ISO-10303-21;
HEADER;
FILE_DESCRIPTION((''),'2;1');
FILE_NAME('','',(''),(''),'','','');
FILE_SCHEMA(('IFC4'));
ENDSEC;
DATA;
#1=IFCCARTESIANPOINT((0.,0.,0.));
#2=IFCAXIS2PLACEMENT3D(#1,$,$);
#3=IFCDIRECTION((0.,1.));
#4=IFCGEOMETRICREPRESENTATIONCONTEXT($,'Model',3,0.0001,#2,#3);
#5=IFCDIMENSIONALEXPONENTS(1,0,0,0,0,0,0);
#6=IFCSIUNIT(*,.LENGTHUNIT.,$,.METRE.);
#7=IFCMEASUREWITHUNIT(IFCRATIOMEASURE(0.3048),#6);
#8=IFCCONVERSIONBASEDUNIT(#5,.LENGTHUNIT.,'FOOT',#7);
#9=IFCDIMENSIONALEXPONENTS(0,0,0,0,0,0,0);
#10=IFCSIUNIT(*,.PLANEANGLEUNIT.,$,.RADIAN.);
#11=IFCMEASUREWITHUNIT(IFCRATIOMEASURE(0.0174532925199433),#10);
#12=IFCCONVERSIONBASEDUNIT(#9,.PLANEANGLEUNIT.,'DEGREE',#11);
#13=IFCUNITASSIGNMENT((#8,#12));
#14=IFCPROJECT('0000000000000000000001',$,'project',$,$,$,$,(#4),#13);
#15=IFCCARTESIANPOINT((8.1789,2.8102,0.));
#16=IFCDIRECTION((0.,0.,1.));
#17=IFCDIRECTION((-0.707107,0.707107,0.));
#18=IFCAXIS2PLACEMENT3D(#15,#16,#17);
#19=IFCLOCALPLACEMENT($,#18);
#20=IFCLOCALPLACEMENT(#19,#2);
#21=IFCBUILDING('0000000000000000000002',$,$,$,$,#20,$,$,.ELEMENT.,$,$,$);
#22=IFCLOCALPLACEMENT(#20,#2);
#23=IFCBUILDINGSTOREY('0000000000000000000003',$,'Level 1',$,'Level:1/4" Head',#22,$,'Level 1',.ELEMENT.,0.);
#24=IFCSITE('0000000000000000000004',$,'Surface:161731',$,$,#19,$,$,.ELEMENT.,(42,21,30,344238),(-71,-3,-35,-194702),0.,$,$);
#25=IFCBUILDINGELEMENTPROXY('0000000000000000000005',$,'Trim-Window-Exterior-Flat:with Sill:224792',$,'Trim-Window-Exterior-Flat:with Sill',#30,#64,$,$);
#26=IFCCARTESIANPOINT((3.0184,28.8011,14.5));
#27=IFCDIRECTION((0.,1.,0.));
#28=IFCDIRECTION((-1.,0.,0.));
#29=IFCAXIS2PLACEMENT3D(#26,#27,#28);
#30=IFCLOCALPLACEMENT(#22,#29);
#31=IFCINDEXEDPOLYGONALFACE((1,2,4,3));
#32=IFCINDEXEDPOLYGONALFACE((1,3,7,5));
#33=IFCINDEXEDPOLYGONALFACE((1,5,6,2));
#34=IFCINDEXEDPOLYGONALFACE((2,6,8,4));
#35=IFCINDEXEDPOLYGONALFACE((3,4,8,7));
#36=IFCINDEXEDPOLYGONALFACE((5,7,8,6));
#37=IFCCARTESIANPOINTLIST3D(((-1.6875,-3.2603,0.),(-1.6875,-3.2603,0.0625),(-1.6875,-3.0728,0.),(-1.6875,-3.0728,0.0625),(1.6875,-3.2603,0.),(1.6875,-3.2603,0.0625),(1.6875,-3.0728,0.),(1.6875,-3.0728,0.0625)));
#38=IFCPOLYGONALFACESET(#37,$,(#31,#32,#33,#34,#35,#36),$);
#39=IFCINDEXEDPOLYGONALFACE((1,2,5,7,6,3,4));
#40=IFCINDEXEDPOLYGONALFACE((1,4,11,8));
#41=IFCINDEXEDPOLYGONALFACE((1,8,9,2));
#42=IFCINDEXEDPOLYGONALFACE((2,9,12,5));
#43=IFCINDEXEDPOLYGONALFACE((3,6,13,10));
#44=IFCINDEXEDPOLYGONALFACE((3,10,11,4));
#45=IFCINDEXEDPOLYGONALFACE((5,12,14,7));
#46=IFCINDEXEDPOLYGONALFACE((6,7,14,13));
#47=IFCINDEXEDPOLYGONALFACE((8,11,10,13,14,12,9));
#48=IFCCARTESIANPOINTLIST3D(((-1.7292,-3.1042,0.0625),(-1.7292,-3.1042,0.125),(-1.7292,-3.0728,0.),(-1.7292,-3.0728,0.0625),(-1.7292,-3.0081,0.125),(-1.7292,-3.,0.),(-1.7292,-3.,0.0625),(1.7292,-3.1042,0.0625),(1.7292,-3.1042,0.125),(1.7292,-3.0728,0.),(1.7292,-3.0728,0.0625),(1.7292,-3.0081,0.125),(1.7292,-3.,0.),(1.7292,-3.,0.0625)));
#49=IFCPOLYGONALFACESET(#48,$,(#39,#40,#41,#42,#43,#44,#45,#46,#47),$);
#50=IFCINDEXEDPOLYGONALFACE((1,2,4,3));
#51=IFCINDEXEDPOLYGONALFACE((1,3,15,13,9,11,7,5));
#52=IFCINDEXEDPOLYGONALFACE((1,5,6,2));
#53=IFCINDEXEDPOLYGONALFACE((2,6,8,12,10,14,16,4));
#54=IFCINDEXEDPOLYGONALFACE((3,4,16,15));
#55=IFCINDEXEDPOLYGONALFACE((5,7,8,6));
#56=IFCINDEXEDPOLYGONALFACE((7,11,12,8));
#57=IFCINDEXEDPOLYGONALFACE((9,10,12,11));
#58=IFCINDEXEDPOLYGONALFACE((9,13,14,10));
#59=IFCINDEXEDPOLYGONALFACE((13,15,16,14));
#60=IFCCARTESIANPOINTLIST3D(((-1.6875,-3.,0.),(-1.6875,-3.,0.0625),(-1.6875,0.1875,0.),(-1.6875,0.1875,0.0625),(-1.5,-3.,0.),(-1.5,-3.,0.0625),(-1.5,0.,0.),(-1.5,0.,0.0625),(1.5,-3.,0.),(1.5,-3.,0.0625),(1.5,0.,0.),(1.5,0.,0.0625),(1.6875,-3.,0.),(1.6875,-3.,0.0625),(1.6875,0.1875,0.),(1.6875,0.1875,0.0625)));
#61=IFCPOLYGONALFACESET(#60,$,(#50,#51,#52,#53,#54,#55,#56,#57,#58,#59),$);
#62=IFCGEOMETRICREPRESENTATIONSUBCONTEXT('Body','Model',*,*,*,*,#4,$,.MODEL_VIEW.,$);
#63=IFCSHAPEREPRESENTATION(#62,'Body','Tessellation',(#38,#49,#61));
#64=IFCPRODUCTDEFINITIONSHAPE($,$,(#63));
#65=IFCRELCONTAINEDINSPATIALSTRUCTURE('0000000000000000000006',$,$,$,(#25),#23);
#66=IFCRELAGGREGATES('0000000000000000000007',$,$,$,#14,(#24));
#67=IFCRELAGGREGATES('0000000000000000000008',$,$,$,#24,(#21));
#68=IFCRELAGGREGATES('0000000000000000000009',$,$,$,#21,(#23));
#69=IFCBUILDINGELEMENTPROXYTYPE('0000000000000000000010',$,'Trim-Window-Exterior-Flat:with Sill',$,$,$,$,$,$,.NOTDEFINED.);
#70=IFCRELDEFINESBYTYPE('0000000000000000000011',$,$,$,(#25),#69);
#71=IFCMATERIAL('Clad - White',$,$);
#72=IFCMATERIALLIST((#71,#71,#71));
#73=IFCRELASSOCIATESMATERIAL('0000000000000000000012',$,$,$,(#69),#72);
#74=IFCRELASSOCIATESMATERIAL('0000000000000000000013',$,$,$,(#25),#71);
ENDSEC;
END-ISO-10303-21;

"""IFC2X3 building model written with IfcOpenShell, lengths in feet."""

from ifc_helpers import new_model, entity, si_unit, converted_unit, direction, frame, frame_2d, origin, place, context, subcontext, project, spatial, polyline, rectangle, outline, extrude, source, transform, mapped, material, material_list, type_object, type_shapes, element, save


model = new_model("IFC2X3")

# Units and contexts
model_context = context("Model", 3, precision=0.0001, world=origin(), true_north=direction((0.0, 1.0)))
body_context = subcontext(model_context, "Body", "Model", "MODEL_VIEW")
ifc_project = project(units=[converted_unit("LENGTHUNIT", "FOOT", entity("IfcRatioMeasure", 0.3048), si_unit("LENGTHUNIT", "METRE"), dimensions=[1, 0, 0, 0, 0, 0, 0]), converted_unit("PLANEANGLEUNIT", "DEGREE", entity("IfcRatioMeasure", 0.0174532925199433), si_unit("PLANEANGLEUNIT", "RADIAN"), dimensions=[0, 0, 0, 0, 0, 0, 0])], contexts=[model_context])

# Site, building, storey
site_placement = place(None, frame((8.1789, 2.8102, 0.0), z_axis=(0.0, 0.0, 1.0), x_axis=(-0.707107, 0.707107, 0.0)))
site = spatial("IfcSite", under=ifc_project, at=site_placement, Name="Surface:161731", CompositionType="ELEMENT", RefLatitude=(42, 21, 30, 344238), RefLongitude=(-71, -3, -35, -194702), RefElevation=0.0)
building_placement = place(site_placement, origin())
building = spatial("IfcBuilding", under=site, at=building_placement, CompositionType="ELEMENT")
storey_placement = place(building_placement, origin())
storey = spatial("IfcBuildingStorey", under=building, at=storey_placement, Name="Level 1", ObjectType="Level:1/4\" Head", LongName="Level 1", CompositionType="ELEMENT", Elevation=0.0)

# Building element proxy
ifc_material_1 = material(Name="Clad - White")
ifc_material_list_1 = material_list([ifc_material_1, ifc_material_1, ifc_material_1])
building_element_proxy_type_1 = type_object("IfcBuildingElementProxyType", Name="Trim-Window-Exterior-Flat:with Sill", PredefinedType="NOTDEFINED", material=ifc_material_list_1)
shared_shape_1 = source(origin(), body_context, "Body", "SweptSolid", [
    extrude(rectangle(XDim=3.375, YDim=0.1875, at=frame_2d((0.0, 0.0), x_axis=(1.0, 0.0))), frame((0.0, -3.1665, 0.0), z_axis=(0.0, 0.0, 1.0), x_axis=(-1.0, 0.0, 0.0)), (0.0, 0.0, 1.0), 0.0625),
    extrude(outline(polyline([(-0.0625, -0.0525), (0.0, -0.0525), (0.0, -0.0211), (0.0625, -0.0211), (0.0625, 0.0517), (0.0, 0.0517), (-0.0625, 0.0436), (-0.0625, -0.0525)])), frame((-1.7292, -3.0517, 0.0625), z_axis=(1.0, 0.0, 0.0), x_axis=(0.0, 0.0, -1.0)), (0.0, 0.0, 1.0), 3.4583),
    extrude(outline(polyline([(-1.6406, -1.6875), (1.5469, -1.6875), (1.5469, -1.5), (-1.4531, -1.5), (-1.4531, 1.5), (1.5469, 1.5), (1.5469, 1.6875), (-1.6406, 1.6875), (-1.6406, -1.6875)])), frame((0.0, -1.4531, 0.0), z_axis=(0.0, 0.0, 1.0), x_axis=(0.0, -1.0, 0.0)), (0.0, 0.0, 1.0), 0.0625),
])
type_shapes(building_element_proxy_type_1, [shared_shape_1])
for number, where, z_axis, x_axis, name in (
    (1, (3.0184, 28.8011, 14.5), (0.0, 1.0, 0.0), (-1.0, 0.0, 0.0), "Trim-Window-Exterior-Flat:with Sill:224792"),
):
    element("IfcBuildingElementProxy", number, at=place(storey_placement, frame(where, z_axis=z_axis, x_axis=x_axis)), inside=storey, type_object=building_element_proxy_type_1, material=ifc_material_1, Name=name, ObjectType="Trim-Window-Exterior-Flat:with Sill", context=body_context, shape_type="MappedRepresentation", body=[
        mapped(shared_shape_1, transform((0.0, 0.0, 0.0), scale=1.0)),
    ])

save(model, "model.ifc")
